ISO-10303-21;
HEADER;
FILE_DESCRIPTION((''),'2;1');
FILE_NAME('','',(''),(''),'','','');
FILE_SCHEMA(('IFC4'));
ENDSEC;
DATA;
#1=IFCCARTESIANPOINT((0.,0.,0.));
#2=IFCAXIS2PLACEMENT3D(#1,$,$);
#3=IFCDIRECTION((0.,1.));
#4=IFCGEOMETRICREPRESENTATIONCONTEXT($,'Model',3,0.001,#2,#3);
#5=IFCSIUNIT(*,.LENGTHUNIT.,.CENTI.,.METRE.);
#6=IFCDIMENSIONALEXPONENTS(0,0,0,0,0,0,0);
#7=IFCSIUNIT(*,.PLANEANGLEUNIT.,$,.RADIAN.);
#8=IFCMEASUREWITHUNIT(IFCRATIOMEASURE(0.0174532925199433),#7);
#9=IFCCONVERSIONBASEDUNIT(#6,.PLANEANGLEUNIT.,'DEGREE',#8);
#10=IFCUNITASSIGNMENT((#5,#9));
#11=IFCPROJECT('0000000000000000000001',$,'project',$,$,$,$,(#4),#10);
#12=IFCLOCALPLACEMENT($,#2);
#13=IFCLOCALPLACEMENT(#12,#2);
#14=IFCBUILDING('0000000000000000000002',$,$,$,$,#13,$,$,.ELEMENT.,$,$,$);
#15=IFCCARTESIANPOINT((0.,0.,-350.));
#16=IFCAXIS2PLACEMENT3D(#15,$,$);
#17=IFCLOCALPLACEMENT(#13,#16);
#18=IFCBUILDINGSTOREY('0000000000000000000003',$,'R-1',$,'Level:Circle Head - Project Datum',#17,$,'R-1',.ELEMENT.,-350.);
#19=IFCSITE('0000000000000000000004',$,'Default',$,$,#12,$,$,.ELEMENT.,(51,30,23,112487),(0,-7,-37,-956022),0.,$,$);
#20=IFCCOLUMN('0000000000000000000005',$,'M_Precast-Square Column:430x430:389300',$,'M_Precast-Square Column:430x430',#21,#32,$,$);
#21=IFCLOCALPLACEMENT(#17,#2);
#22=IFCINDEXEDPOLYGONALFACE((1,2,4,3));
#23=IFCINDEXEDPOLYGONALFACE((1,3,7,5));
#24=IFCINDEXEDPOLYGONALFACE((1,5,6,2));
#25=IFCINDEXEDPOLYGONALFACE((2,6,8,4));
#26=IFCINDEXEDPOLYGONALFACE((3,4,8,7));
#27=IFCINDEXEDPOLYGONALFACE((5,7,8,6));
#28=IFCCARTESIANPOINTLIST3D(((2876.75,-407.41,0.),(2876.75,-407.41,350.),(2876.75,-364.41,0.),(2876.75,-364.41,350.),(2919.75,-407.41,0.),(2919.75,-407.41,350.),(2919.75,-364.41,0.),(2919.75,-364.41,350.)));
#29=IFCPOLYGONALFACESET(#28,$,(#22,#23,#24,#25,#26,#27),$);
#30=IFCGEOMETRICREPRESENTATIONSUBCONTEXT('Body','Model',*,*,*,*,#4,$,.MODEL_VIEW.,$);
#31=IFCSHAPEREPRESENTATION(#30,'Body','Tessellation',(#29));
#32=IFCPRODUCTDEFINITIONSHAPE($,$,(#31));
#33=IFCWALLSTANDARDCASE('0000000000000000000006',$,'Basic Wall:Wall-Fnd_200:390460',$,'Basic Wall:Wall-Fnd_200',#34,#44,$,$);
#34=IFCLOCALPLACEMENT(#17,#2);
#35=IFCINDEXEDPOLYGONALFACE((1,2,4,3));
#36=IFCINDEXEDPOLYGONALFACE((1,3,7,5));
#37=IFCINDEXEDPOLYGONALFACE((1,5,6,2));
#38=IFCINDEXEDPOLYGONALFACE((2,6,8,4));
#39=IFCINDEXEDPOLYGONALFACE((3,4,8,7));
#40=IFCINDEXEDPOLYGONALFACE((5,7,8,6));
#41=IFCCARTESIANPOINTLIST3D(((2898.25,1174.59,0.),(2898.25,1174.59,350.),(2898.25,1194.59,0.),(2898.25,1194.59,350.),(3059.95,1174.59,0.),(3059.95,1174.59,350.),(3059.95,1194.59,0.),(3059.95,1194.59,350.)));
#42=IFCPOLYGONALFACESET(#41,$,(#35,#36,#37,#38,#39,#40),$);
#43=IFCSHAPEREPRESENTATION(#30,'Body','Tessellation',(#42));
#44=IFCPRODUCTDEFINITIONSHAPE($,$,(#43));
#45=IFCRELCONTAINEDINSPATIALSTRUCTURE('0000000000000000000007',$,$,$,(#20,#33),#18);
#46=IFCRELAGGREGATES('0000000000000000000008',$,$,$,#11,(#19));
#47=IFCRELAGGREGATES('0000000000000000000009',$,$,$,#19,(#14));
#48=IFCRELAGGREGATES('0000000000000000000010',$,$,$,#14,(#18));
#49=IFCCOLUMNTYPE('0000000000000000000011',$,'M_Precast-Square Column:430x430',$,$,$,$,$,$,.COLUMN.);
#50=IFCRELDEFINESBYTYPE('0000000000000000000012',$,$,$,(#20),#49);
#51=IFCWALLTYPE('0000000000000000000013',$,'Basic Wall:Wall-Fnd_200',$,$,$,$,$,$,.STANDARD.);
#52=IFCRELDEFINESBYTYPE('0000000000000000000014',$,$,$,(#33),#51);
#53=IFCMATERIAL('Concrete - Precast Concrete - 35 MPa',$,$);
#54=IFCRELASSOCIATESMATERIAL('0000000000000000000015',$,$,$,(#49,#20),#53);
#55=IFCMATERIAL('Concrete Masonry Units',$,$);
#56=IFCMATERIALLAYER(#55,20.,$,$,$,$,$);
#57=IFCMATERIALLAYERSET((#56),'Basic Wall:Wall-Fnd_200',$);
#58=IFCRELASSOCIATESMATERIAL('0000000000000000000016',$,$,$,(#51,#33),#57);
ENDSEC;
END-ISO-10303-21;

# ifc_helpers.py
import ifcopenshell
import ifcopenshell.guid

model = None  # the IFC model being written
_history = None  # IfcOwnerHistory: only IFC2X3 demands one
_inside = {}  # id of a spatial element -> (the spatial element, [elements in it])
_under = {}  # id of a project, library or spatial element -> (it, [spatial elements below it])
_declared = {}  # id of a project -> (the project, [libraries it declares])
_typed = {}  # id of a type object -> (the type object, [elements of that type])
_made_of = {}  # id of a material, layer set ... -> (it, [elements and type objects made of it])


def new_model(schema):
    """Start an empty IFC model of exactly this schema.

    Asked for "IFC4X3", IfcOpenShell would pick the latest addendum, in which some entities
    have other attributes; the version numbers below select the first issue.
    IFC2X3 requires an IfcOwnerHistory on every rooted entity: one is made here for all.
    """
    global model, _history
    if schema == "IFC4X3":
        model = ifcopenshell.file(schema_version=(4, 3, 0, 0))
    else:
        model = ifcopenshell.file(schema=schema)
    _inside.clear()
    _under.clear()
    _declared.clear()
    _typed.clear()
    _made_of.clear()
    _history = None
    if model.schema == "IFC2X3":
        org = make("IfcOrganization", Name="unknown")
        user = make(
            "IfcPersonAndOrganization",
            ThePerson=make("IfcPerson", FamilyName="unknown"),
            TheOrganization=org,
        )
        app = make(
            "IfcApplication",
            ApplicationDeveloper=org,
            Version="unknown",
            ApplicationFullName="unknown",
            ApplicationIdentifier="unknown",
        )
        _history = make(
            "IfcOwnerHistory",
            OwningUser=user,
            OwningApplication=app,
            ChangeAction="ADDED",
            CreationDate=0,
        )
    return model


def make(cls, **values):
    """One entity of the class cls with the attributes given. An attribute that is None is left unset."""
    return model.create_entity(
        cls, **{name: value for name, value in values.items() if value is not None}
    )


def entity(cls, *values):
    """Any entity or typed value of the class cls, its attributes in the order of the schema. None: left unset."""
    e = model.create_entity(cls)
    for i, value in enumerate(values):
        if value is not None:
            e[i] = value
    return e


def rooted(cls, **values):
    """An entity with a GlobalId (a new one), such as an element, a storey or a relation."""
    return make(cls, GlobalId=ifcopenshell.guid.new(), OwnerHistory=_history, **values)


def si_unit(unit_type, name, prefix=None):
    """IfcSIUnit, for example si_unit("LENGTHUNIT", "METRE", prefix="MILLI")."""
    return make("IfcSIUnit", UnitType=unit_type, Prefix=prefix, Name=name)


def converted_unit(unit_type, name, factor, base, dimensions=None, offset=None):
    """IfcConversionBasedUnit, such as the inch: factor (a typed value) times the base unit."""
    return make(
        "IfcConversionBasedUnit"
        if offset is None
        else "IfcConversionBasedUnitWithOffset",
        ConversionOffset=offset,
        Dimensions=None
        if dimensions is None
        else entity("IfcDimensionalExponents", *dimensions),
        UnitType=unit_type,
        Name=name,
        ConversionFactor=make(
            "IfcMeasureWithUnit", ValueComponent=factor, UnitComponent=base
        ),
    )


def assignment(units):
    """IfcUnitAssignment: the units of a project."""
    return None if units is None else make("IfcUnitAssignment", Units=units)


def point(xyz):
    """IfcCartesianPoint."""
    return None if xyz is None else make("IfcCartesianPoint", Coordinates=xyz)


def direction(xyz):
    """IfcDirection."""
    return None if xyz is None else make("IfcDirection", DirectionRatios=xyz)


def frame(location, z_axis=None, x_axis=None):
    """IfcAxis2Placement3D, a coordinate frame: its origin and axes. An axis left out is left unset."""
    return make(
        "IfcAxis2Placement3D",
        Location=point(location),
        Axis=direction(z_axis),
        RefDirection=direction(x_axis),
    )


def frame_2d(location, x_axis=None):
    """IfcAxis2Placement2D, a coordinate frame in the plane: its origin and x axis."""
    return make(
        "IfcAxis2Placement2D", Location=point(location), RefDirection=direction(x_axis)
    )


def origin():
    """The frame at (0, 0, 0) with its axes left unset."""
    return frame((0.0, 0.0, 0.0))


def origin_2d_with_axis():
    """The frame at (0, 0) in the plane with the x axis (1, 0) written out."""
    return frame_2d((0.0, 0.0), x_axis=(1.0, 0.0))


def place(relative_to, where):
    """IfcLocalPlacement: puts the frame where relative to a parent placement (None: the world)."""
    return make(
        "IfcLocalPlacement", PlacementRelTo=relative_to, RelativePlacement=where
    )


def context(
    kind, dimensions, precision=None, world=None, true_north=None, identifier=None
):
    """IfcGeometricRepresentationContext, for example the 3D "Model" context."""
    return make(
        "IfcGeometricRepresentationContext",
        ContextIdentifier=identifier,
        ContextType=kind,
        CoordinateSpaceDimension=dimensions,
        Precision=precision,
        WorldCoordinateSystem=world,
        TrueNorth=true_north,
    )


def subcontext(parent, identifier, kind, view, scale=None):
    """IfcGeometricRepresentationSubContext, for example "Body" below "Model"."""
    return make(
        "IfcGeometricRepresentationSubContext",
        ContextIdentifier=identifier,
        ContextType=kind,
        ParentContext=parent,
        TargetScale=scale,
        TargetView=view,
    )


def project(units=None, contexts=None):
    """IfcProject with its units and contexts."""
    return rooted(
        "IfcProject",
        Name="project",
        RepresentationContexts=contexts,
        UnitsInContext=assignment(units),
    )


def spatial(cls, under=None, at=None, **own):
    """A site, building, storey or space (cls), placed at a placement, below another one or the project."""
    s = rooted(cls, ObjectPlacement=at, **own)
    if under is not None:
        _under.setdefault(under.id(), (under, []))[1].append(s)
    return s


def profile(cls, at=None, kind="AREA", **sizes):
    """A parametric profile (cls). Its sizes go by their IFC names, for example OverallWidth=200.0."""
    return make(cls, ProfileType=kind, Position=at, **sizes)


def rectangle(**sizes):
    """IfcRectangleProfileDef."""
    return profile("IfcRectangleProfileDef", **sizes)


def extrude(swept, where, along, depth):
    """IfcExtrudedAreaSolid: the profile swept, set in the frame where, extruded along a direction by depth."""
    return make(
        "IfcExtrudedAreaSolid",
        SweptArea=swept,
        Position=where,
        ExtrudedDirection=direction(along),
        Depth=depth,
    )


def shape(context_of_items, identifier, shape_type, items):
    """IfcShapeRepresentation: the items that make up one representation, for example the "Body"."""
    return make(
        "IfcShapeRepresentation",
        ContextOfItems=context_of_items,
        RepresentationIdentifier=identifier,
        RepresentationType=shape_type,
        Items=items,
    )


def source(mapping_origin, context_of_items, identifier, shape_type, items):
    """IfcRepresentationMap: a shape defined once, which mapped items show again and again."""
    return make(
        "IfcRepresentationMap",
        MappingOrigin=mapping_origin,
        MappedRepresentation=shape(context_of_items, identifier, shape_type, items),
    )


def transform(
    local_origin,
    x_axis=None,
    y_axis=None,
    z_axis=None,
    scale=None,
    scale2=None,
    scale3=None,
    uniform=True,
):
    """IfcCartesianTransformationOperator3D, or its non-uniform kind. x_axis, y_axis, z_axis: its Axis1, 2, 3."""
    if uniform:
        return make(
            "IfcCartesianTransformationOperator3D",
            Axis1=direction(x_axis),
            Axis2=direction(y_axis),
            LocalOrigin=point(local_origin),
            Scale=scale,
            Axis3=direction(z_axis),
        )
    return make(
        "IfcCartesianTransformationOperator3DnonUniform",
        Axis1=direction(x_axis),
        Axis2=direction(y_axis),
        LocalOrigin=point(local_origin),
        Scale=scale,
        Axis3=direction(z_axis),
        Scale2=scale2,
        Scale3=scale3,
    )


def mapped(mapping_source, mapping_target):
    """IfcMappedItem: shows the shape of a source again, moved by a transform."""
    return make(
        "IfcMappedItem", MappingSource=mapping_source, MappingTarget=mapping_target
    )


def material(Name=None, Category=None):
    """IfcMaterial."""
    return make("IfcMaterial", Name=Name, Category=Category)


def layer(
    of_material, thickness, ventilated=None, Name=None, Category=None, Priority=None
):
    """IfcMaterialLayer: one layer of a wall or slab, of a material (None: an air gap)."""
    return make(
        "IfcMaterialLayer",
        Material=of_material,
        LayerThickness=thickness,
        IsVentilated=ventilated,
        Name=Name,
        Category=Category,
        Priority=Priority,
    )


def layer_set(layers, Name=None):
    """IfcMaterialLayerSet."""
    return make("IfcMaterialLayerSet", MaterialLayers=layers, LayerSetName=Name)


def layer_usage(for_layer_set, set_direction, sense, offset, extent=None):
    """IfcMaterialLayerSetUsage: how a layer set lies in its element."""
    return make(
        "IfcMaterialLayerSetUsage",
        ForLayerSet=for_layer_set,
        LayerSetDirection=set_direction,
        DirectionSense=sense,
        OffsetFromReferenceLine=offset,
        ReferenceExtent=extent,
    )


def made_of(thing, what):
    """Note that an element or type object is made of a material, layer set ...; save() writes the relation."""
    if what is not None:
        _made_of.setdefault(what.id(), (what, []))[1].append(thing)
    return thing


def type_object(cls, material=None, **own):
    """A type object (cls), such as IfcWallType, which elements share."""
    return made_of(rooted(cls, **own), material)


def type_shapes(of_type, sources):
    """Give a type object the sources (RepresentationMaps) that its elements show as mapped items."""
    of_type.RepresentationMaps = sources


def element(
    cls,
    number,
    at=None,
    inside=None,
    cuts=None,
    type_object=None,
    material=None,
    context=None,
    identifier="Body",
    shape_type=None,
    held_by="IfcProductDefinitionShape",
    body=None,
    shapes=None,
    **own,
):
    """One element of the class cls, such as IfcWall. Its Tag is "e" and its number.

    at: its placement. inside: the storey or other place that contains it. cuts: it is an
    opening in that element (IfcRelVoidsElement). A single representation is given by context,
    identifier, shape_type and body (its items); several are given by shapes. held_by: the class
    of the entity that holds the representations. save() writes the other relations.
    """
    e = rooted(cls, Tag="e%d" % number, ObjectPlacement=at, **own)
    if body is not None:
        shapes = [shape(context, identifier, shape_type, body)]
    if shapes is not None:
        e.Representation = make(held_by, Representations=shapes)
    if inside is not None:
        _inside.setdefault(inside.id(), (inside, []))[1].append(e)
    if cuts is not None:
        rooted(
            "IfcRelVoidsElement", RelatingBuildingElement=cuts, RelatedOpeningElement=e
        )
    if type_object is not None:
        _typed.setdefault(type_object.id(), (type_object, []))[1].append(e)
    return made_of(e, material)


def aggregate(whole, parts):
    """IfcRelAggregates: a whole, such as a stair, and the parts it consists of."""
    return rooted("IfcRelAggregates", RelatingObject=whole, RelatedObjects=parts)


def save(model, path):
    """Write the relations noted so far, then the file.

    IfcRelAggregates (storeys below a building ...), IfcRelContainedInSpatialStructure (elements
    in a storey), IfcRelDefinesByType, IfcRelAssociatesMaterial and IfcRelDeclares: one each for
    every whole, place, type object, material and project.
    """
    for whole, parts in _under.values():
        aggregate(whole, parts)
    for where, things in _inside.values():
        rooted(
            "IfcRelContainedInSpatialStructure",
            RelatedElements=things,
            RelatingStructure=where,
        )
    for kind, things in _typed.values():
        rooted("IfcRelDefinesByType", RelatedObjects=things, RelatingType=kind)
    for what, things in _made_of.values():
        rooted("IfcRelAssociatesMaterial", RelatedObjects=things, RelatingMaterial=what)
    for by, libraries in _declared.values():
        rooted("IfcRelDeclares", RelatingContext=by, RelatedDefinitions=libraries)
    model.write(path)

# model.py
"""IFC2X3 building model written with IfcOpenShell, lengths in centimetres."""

from ifc_helpers import new_model, entity, si_unit, converted_unit, direction, frame, frame_2d, origin, origin_2d_with_axis, place, context, subcontext, project, spatial, rectangle, extrude, source, transform, mapped, material, layer, layer_set, layer_usage, type_object, type_shapes, element, save


model = new_model("IFC2X3")

# Units and contexts
model_context = context("Model", 3, precision=0.001, world=origin(), true_north=direction((0.0, 1.0)))
body_context = subcontext(model_context, "Body", "Model", "MODEL_VIEW")
ifc_project = project(units=[si_unit("LENGTHUNIT", "METRE", prefix="CENTI"), converted_unit("PLANEANGLEUNIT", "DEGREE", entity("IfcRatioMeasure", 0.0174532925199433), si_unit("PLANEANGLEUNIT", "RADIAN"), dimensions=[0, 0, 0, 0, 0, 0, 0])], contexts=[model_context])

# Site, building, storey
site_placement = place(None, origin())
site = spatial("IfcSite", under=ifc_project, at=site_placement, Name="Default", CompositionType="ELEMENT", RefLatitude=(51, 30, 23, 112487), RefLongitude=(0, -7, -37, -956022), RefElevation=0.0)
building_placement = place(site_placement, origin())
building = spatial("IfcBuilding", under=site, at=building_placement, CompositionType="ELEMENT")
storey_placement = place(building_placement, frame((0.0, 0.0, -350.0)))
storey = spatial("IfcBuildingStorey", under=building, at=storey_placement, Name="R-1", ObjectType="Level:Circle Head - Project Datum", LongName="R-1", CompositionType="ELEMENT", Elevation=-350.0)

# Column
ifc_material_1 = material(Name="Concrete - Precast Concrete - 35 MPa")
column_type = type_object("IfcColumnType", Name="M_Precast-Square Column:430x430", PredefinedType="COLUMN", material=ifc_material_1)
shared_shape = source(origin(), body_context, "Body", "SweptSolid", [
    extrude(rectangle(XDim=43.0, YDim=43.0, at=origin_2d_with_axis()), frame((0.0, 0.0, -350.0), z_axis=(0.0, 0.0, 1.0), x_axis=(0.0, -1.0, 0.0)), (0.0, 0.0, 1.0), 350.0),
])
type_shapes(column_type, [shared_shape])
for number, where, name in (
    (1, (2898.25, -385.91, 350.0), "M_Precast-Square Column:430x430:389300"),
):
    element("IfcColumn", number, at=place(storey_placement, frame(where)), inside=storey, type_object=column_type, material=ifc_material_1, Name=name, ObjectType="M_Precast-Square Column:430x430", context=body_context, shape_type="MappedRepresentation", body=[
        mapped(shared_shape, transform((0.0, 0.0, 0.0), scale=1.0)),
    ])

# Wall
ifc_material_2 = material(Name="Concrete Masonry Units")
ifc_layer = layer(ifc_material_2, 20.0)
ifc_layer_set = layer_set([ifc_layer], Name="Basic Wall:Wall-Fnd_200")
ifc_layer_usage = layer_usage(ifc_layer_set, "AXIS2", "NEGATIVE", 10.0)
wall_type = type_object("IfcWallType", Name="Basic Wall:Wall-Fnd_200", PredefinedType="STANDARD", material=ifc_layer_set)
wall_placement = place(storey_placement, frame((3059.95, 1184.59, 0.0), z_axis=(0.0, 0.0, 1.0), x_axis=(-1.0, 0.0, 0.0)))
element("IfcWallStandardCase", 2, at=wall_placement, inside=storey, type_object=wall_type, material=ifc_layer_usage, Name="Basic Wall:Wall-Fnd_200:390460", ObjectType="Basic Wall:Wall-Fnd_200", context=body_context, shape_type="SweptSolid", body=[
    extrude(rectangle(XDim=161.7, YDim=20.0, at=frame_2d((80.85, 0.0), x_axis=(-1.0, 0.0))), origin(), (0.0, 0.0, 1.0), 350.0),
])

save(model, "model.ifc")
